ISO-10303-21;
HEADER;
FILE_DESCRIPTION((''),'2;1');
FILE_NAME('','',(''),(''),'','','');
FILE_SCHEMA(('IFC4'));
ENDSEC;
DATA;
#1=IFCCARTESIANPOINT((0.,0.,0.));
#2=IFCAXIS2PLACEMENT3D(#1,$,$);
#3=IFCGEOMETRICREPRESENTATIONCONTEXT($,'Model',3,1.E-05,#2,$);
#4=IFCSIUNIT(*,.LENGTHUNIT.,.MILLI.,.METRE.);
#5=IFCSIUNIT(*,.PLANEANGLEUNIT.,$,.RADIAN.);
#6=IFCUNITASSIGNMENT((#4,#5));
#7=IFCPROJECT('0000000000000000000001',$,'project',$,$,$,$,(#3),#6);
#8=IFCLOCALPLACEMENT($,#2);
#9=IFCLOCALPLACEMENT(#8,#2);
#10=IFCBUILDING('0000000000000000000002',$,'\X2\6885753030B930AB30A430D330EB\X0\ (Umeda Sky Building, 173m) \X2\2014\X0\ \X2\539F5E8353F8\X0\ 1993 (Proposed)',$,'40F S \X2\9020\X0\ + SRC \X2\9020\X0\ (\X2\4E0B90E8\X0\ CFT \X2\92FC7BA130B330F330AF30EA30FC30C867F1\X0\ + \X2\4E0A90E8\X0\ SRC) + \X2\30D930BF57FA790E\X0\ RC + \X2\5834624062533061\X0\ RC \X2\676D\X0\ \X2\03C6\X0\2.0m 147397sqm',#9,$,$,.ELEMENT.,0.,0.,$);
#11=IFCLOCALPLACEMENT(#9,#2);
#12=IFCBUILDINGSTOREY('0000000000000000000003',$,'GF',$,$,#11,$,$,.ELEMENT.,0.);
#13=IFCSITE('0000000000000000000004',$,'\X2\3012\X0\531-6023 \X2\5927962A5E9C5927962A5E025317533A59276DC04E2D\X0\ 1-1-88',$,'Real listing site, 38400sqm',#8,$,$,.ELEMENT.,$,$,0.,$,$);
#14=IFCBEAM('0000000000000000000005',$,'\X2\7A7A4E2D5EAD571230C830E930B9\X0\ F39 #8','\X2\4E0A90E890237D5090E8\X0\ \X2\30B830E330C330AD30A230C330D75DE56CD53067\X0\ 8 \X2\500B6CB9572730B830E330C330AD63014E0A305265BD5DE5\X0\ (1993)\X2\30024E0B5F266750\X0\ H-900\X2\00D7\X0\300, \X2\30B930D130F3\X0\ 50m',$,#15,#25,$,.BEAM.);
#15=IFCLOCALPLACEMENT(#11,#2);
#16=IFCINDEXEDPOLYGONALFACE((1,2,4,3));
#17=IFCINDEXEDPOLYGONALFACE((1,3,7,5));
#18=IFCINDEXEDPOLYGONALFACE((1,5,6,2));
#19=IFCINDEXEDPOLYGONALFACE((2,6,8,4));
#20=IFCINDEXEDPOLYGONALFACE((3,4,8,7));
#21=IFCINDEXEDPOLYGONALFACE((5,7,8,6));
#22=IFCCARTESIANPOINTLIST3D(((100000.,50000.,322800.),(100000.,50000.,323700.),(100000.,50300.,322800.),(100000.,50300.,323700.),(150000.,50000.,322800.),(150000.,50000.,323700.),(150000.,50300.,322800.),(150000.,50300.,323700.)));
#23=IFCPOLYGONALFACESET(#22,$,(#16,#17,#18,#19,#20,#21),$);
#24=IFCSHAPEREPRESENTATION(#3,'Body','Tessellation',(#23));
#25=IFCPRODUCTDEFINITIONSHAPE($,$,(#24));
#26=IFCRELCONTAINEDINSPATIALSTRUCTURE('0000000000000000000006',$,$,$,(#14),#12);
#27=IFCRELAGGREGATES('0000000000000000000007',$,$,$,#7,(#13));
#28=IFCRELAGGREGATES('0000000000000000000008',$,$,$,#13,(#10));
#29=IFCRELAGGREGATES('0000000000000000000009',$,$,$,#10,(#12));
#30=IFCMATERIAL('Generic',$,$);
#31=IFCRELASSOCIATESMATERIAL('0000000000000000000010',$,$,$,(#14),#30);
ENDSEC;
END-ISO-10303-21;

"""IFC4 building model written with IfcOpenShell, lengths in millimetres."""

from ifc_helpers import new_model, si_unit, frame, frame_2d, origin, place, context, project, spatial, rectangle, extrude, material, element, save


model = new_model("IFC4")

# Units and contexts
model_context = context("Model", 3, precision=1e-05, world=origin())
ifc_project = project(units=[si_unit("LENGTHUNIT", "METRE", prefix="MILLI"), si_unit("PLANEANGLEUNIT", "RADIAN")], contexts=[model_context])

# Site, building, storey
site_placement = place(None, origin())
site = spatial("IfcSite", under=ifc_project, at=site_placement, Name="〒531-6023 大阪府大阪市北区大淀中 1-1-88", ObjectType="Real listing site, 38400sqm", CompositionType="ELEMENT", RefElevation=0.0)
building_placement = place(site_placement, origin())
building = spatial("IfcBuilding", under=site, at=building_placement, Name="梅田スカイビル (Umeda Sky Building, 173m) — 原広司 1993 (Proposed)", ObjectType="40F S 造 + SRC 造 (下部 CFT 鋼管コンクリート柱 + 上部 SRC) + ベタ基礎 RC + 場所打ち RC 杭 φ2.0m 147397sqm", CompositionType="ELEMENT", ElevationOfRefHeight=0.0, ElevationOfTerrain=0.0)
storey_placement = place(building_placement, origin())
storey = spatial("IfcBuildingStorey", under=building, at=storey_placement, Name="GF", CompositionType="ELEMENT", Elevation=0.0)

# Beam
ifc_material_1 = material(Name="Generic")
beam_1_placement = place(storey_placement, frame((50000.0, 25000.0, 161400.0)))
element("IfcBeam", 1, at=beam_1_placement, inside=storey, material=ifc_material_1, Name="空中庭園トラス F39 #8", Description="上部連結部 ジャッキアップ工法で 8 個油圧ジャッキ持上げ施工 (1993)。下弦材 H-900×300, スパン 50m", PredefinedType="BEAM", context=model_context, shape_type="SweptSolid", body=[
    extrude(rectangle(XDim=50000.0, YDim=300.0, at=frame_2d((25000.0, 150.0))), frame((50000.0, 25000.0, 161400.0)), (0.0, 0.0, 1.0), 900.0),
])

save(model, "model.ifc")
